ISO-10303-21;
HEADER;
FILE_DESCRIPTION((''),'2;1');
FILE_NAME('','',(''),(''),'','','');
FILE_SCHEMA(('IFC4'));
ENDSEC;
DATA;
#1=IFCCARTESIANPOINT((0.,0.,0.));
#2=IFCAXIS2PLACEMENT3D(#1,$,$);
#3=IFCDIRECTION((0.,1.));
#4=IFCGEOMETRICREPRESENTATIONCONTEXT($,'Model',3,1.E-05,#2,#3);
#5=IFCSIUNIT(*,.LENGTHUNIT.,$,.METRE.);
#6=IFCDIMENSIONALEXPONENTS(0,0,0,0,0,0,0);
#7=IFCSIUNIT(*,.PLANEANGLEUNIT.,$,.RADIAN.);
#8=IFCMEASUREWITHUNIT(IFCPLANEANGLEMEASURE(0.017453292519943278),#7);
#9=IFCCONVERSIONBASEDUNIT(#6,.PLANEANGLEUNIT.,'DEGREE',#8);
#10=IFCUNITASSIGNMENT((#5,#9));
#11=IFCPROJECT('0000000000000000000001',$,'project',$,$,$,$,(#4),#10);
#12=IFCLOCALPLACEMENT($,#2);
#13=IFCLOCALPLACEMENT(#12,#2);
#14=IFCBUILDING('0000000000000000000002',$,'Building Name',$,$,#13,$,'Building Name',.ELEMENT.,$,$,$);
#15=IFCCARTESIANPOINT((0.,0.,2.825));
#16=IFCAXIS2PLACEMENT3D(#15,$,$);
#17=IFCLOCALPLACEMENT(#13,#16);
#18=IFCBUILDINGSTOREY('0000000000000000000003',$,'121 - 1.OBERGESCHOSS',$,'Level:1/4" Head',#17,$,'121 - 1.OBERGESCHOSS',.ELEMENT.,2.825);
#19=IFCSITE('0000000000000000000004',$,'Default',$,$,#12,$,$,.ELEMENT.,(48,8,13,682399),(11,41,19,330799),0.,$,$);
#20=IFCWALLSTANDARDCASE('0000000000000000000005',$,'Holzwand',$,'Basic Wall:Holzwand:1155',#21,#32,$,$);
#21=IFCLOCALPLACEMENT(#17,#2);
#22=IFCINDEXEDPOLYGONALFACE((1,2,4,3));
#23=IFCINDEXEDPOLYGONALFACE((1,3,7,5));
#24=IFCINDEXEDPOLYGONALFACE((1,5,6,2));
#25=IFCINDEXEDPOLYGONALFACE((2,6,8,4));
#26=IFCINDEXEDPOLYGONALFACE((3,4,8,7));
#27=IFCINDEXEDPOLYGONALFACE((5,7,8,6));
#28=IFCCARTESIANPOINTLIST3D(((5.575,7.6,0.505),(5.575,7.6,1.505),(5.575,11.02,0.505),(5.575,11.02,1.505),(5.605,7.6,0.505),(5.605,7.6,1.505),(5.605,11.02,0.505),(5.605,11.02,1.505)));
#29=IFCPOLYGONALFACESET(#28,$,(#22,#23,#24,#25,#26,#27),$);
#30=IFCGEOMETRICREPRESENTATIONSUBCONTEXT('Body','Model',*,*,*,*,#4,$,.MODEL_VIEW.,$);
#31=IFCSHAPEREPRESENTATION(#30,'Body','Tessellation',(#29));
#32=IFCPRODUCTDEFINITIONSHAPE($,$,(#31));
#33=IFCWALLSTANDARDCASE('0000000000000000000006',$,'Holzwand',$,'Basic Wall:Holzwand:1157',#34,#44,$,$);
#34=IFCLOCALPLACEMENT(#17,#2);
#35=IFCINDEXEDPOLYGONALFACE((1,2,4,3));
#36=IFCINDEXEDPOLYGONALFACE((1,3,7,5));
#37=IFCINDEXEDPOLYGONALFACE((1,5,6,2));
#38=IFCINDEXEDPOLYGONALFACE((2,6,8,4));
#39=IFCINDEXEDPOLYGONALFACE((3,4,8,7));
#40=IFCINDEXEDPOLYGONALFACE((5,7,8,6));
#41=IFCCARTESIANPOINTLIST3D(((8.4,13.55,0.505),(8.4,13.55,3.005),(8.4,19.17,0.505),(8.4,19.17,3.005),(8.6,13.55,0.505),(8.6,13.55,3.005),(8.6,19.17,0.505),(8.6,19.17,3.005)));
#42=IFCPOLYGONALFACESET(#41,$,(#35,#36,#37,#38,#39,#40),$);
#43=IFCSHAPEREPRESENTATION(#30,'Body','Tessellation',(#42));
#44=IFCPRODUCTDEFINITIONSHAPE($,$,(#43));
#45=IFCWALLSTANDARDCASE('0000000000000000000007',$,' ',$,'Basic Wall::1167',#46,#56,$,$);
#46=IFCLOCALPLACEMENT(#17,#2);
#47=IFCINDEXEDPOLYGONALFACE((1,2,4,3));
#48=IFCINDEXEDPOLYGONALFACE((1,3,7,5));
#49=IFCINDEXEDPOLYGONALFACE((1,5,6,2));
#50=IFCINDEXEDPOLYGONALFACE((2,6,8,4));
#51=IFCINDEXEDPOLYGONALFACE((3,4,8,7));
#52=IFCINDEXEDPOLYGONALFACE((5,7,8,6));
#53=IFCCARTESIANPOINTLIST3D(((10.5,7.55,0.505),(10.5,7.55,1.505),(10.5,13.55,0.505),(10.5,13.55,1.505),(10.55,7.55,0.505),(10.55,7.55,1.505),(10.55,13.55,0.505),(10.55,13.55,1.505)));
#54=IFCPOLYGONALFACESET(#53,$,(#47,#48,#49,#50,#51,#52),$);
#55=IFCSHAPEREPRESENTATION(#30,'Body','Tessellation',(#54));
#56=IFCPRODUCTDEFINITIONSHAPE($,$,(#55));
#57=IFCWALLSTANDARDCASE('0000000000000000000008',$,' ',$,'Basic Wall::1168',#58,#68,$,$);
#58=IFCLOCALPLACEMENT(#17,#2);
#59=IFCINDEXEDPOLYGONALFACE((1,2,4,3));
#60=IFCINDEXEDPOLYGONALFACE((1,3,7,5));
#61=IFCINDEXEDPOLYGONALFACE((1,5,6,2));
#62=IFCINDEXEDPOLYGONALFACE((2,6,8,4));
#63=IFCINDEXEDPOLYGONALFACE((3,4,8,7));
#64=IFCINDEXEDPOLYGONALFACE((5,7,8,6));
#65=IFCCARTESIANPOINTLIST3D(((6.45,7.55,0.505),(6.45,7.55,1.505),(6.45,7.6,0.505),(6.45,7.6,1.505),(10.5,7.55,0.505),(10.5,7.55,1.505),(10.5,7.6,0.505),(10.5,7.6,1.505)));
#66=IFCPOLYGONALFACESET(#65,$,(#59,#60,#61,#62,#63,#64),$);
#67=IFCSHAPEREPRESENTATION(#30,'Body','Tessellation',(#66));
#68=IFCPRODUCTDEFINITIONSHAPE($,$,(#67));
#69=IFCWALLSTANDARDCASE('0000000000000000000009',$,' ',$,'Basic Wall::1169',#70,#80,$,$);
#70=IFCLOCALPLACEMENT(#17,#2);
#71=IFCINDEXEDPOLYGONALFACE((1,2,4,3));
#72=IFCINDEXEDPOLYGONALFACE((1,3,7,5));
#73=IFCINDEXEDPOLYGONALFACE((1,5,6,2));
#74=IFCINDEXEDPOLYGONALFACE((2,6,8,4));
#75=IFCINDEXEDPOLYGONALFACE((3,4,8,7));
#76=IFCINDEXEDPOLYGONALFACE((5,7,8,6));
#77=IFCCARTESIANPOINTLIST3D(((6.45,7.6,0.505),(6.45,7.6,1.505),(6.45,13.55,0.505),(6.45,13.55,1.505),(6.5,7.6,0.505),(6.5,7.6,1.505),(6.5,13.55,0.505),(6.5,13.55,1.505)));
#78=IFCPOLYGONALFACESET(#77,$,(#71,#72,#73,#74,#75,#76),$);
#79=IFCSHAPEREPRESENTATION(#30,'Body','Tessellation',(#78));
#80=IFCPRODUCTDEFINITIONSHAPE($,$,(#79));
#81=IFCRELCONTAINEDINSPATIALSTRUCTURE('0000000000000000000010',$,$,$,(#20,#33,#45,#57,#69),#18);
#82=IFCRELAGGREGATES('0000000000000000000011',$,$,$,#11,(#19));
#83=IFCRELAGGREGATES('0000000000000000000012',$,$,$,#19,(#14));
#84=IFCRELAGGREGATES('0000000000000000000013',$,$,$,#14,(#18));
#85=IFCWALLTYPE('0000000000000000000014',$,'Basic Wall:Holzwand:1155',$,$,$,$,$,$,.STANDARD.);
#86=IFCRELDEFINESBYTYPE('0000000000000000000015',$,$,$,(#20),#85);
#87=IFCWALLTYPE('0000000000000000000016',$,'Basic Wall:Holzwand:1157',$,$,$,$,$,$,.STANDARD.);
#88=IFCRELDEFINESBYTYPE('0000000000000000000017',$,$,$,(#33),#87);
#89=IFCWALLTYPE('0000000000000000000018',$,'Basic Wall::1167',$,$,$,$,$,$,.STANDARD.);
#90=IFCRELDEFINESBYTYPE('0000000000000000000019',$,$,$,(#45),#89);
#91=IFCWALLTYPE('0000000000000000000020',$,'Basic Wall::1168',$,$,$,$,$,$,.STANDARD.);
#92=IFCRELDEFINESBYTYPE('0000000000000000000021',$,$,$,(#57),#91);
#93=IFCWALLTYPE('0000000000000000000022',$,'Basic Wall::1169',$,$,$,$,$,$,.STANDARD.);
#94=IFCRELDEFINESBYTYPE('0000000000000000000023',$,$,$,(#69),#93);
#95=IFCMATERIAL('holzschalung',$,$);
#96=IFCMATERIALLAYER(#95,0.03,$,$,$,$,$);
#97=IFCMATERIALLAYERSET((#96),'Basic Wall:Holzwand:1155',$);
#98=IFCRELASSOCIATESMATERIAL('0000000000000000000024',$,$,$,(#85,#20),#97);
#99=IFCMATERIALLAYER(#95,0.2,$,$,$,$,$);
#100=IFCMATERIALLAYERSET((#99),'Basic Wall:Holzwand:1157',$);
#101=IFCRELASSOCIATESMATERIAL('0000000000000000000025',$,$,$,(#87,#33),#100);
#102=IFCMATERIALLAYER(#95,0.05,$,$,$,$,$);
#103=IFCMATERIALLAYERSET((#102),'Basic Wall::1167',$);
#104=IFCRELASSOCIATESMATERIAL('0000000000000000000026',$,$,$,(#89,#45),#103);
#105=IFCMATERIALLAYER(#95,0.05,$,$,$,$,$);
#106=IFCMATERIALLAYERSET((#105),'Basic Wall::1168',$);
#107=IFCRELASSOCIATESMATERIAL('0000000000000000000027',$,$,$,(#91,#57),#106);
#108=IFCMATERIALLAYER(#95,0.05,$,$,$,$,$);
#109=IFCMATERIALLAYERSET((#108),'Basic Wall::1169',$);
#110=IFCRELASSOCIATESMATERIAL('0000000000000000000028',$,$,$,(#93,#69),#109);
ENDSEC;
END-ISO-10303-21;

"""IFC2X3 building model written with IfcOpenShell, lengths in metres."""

from ifc_helpers import new_model, entity, si_unit, converted_unit, direction, frame, frame_2d, origin, place, context, subcontext, project, spatial, rectangle, extrude, material, layer, layer_set, layer_usage, type_object, element, save


model = new_model("IFC2X3")

# Units and contexts
model_context = context("Model", 3, precision=1e-05, world=origin(), true_north=direction((0.0, 1.0)))
body_context = subcontext(model_context, "Body", "Model", "MODEL_VIEW")
ifc_project = project(units=[si_unit("LENGTHUNIT", "METRE"), converted_unit("PLANEANGLEUNIT", "DEGREE", entity("IfcPlaneAngleMeasure", 0.017453292519943278), si_unit("PLANEANGLEUNIT", "RADIAN"), dimensions=[0, 0, 0, 0, 0, 0, 0])], contexts=[model_context])

# Site, building, storey
site_placement = place(None, origin())
site = spatial("IfcSite", under=ifc_project, at=site_placement, Name="Default", CompositionType="ELEMENT", RefLatitude=(48, 8, 13, 682399), RefLongitude=(11, 41, 19, 330799), RefElevation=0.0)
building_placement = place(site_placement, origin())
building = spatial("IfcBuilding", under=site, at=building_placement, Name="Building Name", LongName="Building Name", CompositionType="ELEMENT")
storey_placement = place(building_placement, frame((0.0, 0.0, 2.825)))
storey = spatial("IfcBuildingStorey", under=building, at=storey_placement, Name="121 - 1.OBERGESCHOSS", ObjectType="Level:1/4\" Head", LongName="121 - 1.OBERGESCHOSS", CompositionType="ELEMENT", Elevation=2.825)

# Shared definitions
ifc_material = material(Name="holzschalung")

# Walls
ifc_layer_1 = layer(ifc_material, 0.03)
ifc_layer_set_1 = layer_set([ifc_layer_1], Name="Basic Wall:Holzwand:1155")
ifc_layer_usage_1 = layer_usage(ifc_layer_set_1, "AXIS2", "NEGATIVE", 0.015)
wall_type_1 = type_object("IfcWallType", Name="Basic Wall:Holzwand:1155", PredefinedType="STANDARD", material=ifc_layer_set_1)
wall_1_placement = place(storey_placement, frame((5.59, 7.6, 0.505), z_axis=(0.0, 0.0, 1.0), x_axis=(0.0, 1.0, 0.0)))
element("IfcWallStandardCase", 1, at=wall_1_placement, inside=storey, type_object=wall_type_1, material=ifc_layer_usage_1, Name="Holzwand", ObjectType="Basic Wall:Holzwand:1155", context=body_context, shape_type="SweptSolid", body=[
    extrude(rectangle(XDim=3.42, YDim=0.03, at=frame_2d((1.71, 0.0), x_axis=(-1.0, 0.0))), origin(), (0.0, 0.0, 1.0), 1.0),
])
ifc_layer_2 = layer(ifc_material, 0.2)
ifc_layer_set_2 = layer_set([ifc_layer_2], Name="Basic Wall:Holzwand:1157")
ifc_layer_usage_2 = layer_usage(ifc_layer_set_2, "AXIS2", "NEGATIVE", 0.1)
wall_type_2 = type_object("IfcWallType", Name="Basic Wall:Holzwand:1157", PredefinedType="STANDARD", material=ifc_layer_set_2)
wall_2_placement = place(storey_placement, frame((8.5, 13.55, 0.505), z_axis=(0.0, 0.0, 1.0), x_axis=(0.0, 1.0, 0.0)))
element("IfcWallStandardCase", 2, at=wall_2_placement, inside=storey, type_object=wall_type_2, material=ifc_layer_usage_2, Name="Holzwand", ObjectType="Basic Wall:Holzwand:1157", context=body_context, shape_type="SweptSolid", body=[
    extrude(rectangle(XDim=5.62, YDim=0.2, at=frame_2d((2.81, 0.0), x_axis=(-1.0, 0.0))), origin(), (0.0, 0.0, 1.0), 2.5),
])
ifc_layer_3 = layer(ifc_material, 0.05)
ifc_layer_set_3 = layer_set([ifc_layer_3], Name="Basic Wall::1167")
ifc_layer_usage_3 = layer_usage(ifc_layer_set_3, "AXIS2", "NEGATIVE", 0.025)
wall_type_3 = type_object("IfcWallType", Name="Basic Wall::1167", PredefinedType="STANDARD", material=ifc_layer_set_3)
wall_3_placement = place(storey_placement, frame((10.525, 13.55, 0.505), z_axis=(0.0, 0.0, 1.0), x_axis=(0.0, -1.0, 0.0)))
element("IfcWallStandardCase", 3, at=wall_3_placement, inside=storey, type_object=wall_type_3, material=ifc_layer_usage_3, Name=" ", ObjectType="Basic Wall::1167", context=body_context, shape_type="SweptSolid", body=[
    extrude(rectangle(XDim=6.0, YDim=0.05, at=frame_2d((3.0, 0.0), x_axis=(-1.0, 0.0))), origin(), (0.0, 0.0, 1.0), 1.0),
])
ifc_layer_4 = layer(ifc_material, 0.05)
ifc_layer_set_4 = layer_set([ifc_layer_4], Name="Basic Wall::1168")
ifc_layer_usage_4 = layer_usage(ifc_layer_set_4, "AXIS2", "NEGATIVE", 0.025)
wall_type_4 = type_object("IfcWallType", Name="Basic Wall::1168", PredefinedType="STANDARD", material=ifc_layer_set_4)
wall_4_placement = place(storey_placement, frame((10.5, 7.575, 0.505), z_axis=(0.0, 0.0, 1.0), x_axis=(-1.0, 0.0, 0.0)))
element("IfcWallStandardCase", 4, at=wall_4_placement, inside=storey, type_object=wall_type_4, material=ifc_layer_usage_4, Name=" ", ObjectType="Basic Wall::1168", context=body_context, shape_type="SweptSolid", body=[
    extrude(rectangle(XDim=4.05, YDim=0.05, at=frame_2d((2.025, 0.0), x_axis=(-1.0, 0.0))), origin(), (0.0, 0.0, 1.0), 1.0),
])
ifc_layer_5 = layer(ifc_material, 0.05)
ifc_layer_set_5 = layer_set([ifc_layer_5], Name="Basic Wall::1169")
ifc_layer_usage_5 = layer_usage(ifc_layer_set_5, "AXIS2", "NEGATIVE", 0.025)
wall_type_5 = type_object("IfcWallType", Name="Basic Wall::1169", PredefinedType="STANDARD", material=ifc_layer_set_5)
wall_5_placement = place(storey_placement, frame((6.475, 7.6, 0.505), z_axis=(0.0, 0.0, 1.0), x_axis=(0.0, 1.0, 0.0)))
element("IfcWallStandardCase", 5, at=wall_5_placement, inside=storey, type_object=wall_type_5, material=ifc_layer_usage_5, Name=" ", ObjectType="Basic Wall::1169", context=body_context, shape_type="SweptSolid", body=[
    extrude(rectangle(XDim=5.95, YDim=0.05, at=frame_2d((2.975, 0.0), x_axis=(-1.0, 0.0))), origin(), (0.0, 0.0, 1.0), 1.0),
])

save(model, "model.ifc")
